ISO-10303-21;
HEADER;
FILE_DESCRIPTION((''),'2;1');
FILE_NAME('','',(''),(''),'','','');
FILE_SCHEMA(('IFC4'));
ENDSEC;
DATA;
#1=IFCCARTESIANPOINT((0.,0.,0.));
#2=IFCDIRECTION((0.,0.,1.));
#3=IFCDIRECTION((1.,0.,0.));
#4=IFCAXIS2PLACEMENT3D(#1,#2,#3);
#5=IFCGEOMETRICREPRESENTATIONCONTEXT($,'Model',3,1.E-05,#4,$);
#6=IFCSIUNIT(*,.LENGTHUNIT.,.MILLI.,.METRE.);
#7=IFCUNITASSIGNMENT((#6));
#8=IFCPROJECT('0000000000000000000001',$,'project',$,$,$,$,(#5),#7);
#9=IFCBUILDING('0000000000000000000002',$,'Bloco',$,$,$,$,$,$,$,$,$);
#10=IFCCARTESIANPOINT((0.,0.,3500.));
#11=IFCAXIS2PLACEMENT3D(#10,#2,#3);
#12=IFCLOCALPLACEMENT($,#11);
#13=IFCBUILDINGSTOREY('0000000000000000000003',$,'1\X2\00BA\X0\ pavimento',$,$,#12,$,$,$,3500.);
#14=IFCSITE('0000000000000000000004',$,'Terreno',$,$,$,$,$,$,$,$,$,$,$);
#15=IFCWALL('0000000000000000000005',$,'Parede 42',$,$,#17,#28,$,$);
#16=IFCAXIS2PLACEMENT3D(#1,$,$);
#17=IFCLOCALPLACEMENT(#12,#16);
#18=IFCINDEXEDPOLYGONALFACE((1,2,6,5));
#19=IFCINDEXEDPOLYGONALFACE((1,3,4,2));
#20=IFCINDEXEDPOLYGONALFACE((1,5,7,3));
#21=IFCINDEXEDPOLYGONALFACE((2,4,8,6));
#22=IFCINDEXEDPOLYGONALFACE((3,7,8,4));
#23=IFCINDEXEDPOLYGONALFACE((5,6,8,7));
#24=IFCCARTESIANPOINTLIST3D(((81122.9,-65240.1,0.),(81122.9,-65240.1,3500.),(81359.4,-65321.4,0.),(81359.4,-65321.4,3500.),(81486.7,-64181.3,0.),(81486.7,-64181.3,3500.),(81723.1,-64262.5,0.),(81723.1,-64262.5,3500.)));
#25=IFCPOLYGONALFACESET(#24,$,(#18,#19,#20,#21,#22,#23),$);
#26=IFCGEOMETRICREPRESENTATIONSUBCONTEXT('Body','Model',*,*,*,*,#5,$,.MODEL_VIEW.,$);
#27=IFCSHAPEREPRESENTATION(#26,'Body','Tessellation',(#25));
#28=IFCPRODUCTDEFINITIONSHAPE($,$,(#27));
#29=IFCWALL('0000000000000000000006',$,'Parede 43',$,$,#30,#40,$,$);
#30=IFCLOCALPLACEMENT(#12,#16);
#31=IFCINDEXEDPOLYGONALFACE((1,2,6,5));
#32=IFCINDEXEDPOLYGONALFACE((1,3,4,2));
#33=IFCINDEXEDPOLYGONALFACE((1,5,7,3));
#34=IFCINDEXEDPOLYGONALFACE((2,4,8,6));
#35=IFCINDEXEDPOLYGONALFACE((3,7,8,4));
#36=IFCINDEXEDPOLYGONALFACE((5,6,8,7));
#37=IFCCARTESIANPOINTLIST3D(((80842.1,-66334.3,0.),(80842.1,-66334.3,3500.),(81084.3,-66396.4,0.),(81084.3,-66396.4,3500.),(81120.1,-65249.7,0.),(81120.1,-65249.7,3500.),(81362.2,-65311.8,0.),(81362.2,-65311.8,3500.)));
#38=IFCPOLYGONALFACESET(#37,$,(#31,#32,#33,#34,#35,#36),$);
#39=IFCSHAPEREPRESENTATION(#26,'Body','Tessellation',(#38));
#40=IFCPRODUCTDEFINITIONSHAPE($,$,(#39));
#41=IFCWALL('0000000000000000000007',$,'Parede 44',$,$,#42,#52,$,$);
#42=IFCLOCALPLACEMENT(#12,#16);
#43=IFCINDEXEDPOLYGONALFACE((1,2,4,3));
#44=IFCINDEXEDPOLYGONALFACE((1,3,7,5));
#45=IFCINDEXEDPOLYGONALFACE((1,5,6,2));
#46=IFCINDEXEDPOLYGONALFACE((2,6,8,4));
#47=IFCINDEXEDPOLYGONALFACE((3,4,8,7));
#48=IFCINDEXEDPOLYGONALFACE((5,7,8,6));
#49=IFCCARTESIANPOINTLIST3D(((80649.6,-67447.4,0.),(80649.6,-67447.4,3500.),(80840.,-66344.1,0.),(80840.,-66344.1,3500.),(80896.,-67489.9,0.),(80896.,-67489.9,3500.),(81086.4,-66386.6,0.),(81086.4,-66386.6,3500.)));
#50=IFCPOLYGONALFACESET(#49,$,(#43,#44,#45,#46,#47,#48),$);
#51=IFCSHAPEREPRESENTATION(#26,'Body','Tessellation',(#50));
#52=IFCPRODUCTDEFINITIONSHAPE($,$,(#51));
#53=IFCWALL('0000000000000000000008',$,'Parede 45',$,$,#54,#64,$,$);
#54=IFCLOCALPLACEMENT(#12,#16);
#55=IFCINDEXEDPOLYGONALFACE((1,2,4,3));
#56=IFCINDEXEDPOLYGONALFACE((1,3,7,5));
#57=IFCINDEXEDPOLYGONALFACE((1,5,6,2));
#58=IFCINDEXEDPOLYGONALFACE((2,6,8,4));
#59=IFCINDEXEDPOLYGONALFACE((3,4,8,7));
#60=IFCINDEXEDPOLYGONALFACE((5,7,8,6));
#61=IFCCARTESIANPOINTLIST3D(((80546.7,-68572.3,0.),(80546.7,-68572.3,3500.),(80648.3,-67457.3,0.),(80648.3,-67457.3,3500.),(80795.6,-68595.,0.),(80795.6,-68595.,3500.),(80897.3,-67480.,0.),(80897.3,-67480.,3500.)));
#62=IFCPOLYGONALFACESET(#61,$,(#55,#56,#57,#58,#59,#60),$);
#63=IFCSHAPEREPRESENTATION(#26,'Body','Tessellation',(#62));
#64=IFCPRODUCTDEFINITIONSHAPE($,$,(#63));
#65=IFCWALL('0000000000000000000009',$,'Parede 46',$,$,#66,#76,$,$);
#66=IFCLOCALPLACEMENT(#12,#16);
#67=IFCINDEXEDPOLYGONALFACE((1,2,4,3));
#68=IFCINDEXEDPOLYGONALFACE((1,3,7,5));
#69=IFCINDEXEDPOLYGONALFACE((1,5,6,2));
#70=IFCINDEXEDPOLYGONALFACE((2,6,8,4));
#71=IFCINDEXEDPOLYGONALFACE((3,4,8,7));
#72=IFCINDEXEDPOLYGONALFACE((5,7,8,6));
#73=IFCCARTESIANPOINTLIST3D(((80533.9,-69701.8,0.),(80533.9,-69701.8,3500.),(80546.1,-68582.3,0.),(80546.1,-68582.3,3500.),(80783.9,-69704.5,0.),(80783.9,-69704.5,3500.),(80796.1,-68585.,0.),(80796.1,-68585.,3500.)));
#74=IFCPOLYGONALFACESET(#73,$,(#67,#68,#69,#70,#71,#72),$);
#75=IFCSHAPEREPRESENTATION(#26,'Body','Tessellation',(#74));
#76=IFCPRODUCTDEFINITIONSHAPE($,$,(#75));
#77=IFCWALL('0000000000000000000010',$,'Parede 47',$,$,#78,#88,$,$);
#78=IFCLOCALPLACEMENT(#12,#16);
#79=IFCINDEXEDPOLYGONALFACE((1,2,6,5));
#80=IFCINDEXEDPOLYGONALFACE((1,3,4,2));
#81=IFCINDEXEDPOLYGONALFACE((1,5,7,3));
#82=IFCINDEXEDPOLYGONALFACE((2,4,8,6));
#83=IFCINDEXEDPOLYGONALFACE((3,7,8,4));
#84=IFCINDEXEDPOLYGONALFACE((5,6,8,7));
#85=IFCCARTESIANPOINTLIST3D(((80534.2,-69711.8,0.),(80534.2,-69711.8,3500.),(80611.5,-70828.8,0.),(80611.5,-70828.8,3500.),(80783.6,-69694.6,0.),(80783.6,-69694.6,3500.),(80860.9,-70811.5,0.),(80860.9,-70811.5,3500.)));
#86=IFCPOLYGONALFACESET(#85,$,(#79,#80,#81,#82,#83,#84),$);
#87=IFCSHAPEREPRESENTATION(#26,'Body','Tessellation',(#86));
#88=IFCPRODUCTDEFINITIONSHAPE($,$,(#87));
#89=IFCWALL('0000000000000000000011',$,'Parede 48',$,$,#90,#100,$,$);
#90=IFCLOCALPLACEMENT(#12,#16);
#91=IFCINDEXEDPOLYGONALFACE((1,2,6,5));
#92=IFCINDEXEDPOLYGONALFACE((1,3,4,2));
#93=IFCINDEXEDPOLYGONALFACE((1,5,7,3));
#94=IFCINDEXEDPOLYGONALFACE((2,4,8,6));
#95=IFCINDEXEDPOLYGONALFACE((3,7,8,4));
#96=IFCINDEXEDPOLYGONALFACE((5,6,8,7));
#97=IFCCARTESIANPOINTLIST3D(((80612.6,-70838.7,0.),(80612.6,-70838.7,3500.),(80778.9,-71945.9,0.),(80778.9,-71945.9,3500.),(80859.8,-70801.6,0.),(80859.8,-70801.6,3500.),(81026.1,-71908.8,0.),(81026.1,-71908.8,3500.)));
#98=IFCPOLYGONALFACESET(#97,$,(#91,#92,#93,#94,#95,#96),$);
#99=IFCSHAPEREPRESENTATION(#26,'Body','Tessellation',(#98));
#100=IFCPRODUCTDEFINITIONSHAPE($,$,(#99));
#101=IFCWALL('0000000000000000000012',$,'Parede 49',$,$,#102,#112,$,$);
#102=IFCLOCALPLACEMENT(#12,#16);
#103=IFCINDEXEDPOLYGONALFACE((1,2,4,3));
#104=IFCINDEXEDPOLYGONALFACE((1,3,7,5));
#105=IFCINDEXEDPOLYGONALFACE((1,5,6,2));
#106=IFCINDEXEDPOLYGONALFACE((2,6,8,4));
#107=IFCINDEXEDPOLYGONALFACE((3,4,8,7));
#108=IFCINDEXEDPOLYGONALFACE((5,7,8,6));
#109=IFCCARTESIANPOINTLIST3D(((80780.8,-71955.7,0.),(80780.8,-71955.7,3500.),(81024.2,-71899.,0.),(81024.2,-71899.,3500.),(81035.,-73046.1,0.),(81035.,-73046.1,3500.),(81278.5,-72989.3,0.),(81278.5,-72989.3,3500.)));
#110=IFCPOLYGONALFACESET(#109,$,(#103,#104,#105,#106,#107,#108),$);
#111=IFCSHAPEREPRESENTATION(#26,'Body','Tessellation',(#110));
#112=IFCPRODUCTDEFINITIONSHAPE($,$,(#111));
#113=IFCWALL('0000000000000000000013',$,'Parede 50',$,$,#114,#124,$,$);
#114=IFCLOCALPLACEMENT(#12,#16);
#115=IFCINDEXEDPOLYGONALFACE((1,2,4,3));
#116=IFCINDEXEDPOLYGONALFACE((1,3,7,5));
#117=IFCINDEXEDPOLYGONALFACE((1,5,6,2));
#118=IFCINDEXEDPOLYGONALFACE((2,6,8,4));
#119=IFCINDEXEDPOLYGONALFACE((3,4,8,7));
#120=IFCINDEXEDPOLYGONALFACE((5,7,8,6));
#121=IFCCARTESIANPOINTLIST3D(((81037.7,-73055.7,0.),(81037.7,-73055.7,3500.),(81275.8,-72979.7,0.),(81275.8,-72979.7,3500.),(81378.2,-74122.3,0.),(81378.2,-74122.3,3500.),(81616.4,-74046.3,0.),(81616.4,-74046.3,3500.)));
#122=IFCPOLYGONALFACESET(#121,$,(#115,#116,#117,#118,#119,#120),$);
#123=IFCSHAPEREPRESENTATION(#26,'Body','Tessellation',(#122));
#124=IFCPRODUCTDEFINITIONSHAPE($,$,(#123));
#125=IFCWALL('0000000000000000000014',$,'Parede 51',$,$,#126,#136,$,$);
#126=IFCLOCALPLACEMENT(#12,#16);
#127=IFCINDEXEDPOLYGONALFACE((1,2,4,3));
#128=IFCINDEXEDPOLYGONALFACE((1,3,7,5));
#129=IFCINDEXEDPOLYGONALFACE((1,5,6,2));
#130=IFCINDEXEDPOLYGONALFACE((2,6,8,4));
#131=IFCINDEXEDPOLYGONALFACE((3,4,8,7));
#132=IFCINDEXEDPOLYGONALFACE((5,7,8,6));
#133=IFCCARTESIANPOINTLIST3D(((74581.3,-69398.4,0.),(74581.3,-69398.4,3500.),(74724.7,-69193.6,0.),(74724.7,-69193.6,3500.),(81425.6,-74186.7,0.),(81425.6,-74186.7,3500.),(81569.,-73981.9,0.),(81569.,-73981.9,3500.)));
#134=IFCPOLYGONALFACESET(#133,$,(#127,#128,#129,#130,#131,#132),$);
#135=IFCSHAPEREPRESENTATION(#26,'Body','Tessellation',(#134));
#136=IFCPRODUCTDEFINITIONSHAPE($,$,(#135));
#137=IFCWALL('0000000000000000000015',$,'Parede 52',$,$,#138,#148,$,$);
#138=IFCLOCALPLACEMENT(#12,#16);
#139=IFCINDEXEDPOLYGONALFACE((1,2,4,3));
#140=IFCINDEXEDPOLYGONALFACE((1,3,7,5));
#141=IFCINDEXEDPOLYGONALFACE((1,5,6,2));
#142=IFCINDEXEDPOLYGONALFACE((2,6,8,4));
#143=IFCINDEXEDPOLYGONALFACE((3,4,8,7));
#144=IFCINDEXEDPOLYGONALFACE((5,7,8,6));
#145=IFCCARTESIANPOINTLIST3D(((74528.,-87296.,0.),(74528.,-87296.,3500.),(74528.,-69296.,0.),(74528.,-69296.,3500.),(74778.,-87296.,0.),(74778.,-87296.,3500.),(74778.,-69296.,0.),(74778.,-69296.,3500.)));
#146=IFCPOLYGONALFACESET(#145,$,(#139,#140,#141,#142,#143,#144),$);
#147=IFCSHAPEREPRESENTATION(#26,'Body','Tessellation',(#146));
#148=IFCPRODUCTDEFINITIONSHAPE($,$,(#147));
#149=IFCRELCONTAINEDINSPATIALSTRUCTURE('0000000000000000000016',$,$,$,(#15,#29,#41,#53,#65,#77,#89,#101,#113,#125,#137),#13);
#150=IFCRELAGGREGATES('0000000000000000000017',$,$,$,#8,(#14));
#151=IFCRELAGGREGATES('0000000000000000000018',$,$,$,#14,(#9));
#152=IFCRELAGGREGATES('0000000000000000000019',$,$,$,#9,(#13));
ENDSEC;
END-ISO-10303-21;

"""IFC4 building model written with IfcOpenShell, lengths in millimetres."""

from ifc_helpers import new_model, si_unit, frame, origin, origin_with_axes, place, context, subcontext, project, spatial, polyline, outline, extrude, element, save


model = new_model("IFC4")

# Units and contexts
model_context = context("Model", 3, precision=1e-05, world=origin_with_axes())
body_context = subcontext(model_context, "Body", "Model", "MODEL_VIEW")
ifc_project = project(units=[si_unit("LENGTHUNIT", "METRE", prefix="MILLI")], contexts=[model_context])

# Site, building, storey
site = spatial("IfcSite", under=ifc_project, Name="Terreno")
building = spatial("IfcBuilding", under=site, Name="Bloco")
storey_placement = place(None, frame((0.0, 0.0, 3500.0), z_axis=(0.0, 0.0, 1.0), x_axis=(1.0, 0.0, 0.0)))
storey = spatial("IfcBuildingStorey", under=building, at=storey_placement, Name="1º pavimento", Elevation=3500.0)

# Walls
wall_1_placement = place(storey_placement, origin_with_axes())
element("IfcWall", 1, at=wall_1_placement, inside=storey, Name="Parede 42", context=body_context, shape_type="SweptSolid", body=[
    extrude(outline(polyline([(81723.1, -64262.5), (81359.4, -65321.4), (81122.9, -65240.1), (81486.7, -64181.3), (81723.1, -64262.5)])), origin(), (0.0, 0.0, 1.0), 3500.0),
])
wall_2_placement = place(storey_placement, origin_with_axes())
element("IfcWall", 2, at=wall_2_placement, inside=storey, Name="Parede 43", context=body_context, shape_type="SweptSolid", body=[
    extrude(outline(polyline([(81362.2, -65311.8), (81084.3, -66396.4), (80842.1, -66334.3), (81120.1, -65249.7), (81362.2, -65311.8)])), origin(), (0.0, 0.0, 1.0), 3500.0),
])
wall_3_placement = place(storey_placement, origin_with_axes())
element("IfcWall", 3, at=wall_3_placement, inside=storey, Name="Parede 44", context=body_context, shape_type="SweptSolid", body=[
    extrude(outline(polyline([(81086.4, -66386.6), (80896.0, -67489.9), (80649.6, -67447.4), (80840.0, -66344.1), (81086.4, -66386.6)])), origin(), (0.0, 0.0, 1.0), 3500.0),
])
wall_4_placement = place(storey_placement, origin_with_axes())
element("IfcWall", 4, at=wall_4_placement, inside=storey, Name="Parede 45", context=body_context, shape_type="SweptSolid", body=[
    extrude(outline(polyline([(80897.3, -67480.0), (80795.6, -68595.0), (80546.7, -68572.3), (80648.3, -67457.3), (80897.3, -67480.0)])), origin(), (0.0, 0.0, 1.0), 3500.0),
])
wall_5_placement = place(storey_placement, origin_with_axes())
element("IfcWall", 5, at=wall_5_placement, inside=storey, Name="Parede 46", context=body_context, shape_type="SweptSolid", body=[
    extrude(outline(polyline([(80796.1, -68585.0), (80783.9, -69704.5), (80533.9, -69701.8), (80546.1, -68582.3), (80796.1, -68585.0)])), origin(), (0.0, 0.0, 1.0), 3500.0),
])
wall_6_placement = place(storey_placement, origin_with_axes())
element("IfcWall", 6, at=wall_6_placement, inside=storey, Name="Parede 47", context=body_context, shape_type="SweptSolid", body=[
    extrude(outline(polyline([(80783.6, -69694.6), (80860.9, -70811.5), (80611.5, -70828.8), (80534.2, -69711.8), (80783.6, -69694.6)])), origin(), (0.0, 0.0, 1.0), 3500.0),
])
wall_7_placement = place(storey_placement, origin_with_axes())
element("IfcWall", 7, at=wall_7_placement, inside=storey, Name="Parede 48", context=body_context, shape_type="SweptSolid", body=[
    extrude(outline(polyline([(80859.8, -70801.6), (81026.1, -71908.8), (80778.9, -71945.9), (80612.6, -70838.7), (80859.8, -70801.6)])), origin(), (0.0, 0.0, 1.0), 3500.0),
])
wall_8_placement = place(storey_placement, origin_with_axes())
element("IfcWall", 8, at=wall_8_placement, inside=storey, Name="Parede 49", context=body_context, shape_type="SweptSolid", body=[
    extrude(outline(polyline([(81024.2, -71899.0), (81278.5, -72989.3), (81035.0, -73046.1), (80780.8, -71955.7), (81024.2, -71899.0)])), origin(), (0.0, 0.0, 1.0), 3500.0),
])
wall_9_placement = place(storey_placement, origin_with_axes())
element("IfcWall", 9, at=wall_9_placement, inside=storey, Name="Parede 50", context=body_context, shape_type="SweptSolid", body=[
    extrude(outline(polyline([(81275.8, -72979.7), (81616.4, -74046.3), (81378.2, -74122.3), (81037.7, -73055.7), (81275.8, -72979.7)])), origin(), (0.0, 0.0, 1.0), 3500.0),
])
wall_10_placement = place(storey_placement, origin_with_axes())
element("IfcWall", 10, at=wall_10_placement, inside=storey, Name="Parede 51", context=body_context, shape_type="SweptSolid", body=[
    extrude(outline(polyline([(81425.6, -74186.7), (74581.3, -69398.4), (74724.7, -69193.6), (81569.0, -73981.9), (81425.6, -74186.7)])), origin(), (0.0, 0.0, 1.0), 3500.0),
])
wall_11_placement = place(storey_placement, origin_with_axes())
element("IfcWall", 11, at=wall_11_placement, inside=storey, Name="Parede 52", context=body_context, shape_type="SweptSolid", body=[
    extrude(outline(polyline([(74778.0, -69296.0), (74778.0, -87296.0), (74528.0, -87296.0), (74528.0, -69296.0), (74778.0, -69296.0)])), origin(), (0.0, 0.0, 1.0), 3500.0),
])

save(model, "model.ifc")
